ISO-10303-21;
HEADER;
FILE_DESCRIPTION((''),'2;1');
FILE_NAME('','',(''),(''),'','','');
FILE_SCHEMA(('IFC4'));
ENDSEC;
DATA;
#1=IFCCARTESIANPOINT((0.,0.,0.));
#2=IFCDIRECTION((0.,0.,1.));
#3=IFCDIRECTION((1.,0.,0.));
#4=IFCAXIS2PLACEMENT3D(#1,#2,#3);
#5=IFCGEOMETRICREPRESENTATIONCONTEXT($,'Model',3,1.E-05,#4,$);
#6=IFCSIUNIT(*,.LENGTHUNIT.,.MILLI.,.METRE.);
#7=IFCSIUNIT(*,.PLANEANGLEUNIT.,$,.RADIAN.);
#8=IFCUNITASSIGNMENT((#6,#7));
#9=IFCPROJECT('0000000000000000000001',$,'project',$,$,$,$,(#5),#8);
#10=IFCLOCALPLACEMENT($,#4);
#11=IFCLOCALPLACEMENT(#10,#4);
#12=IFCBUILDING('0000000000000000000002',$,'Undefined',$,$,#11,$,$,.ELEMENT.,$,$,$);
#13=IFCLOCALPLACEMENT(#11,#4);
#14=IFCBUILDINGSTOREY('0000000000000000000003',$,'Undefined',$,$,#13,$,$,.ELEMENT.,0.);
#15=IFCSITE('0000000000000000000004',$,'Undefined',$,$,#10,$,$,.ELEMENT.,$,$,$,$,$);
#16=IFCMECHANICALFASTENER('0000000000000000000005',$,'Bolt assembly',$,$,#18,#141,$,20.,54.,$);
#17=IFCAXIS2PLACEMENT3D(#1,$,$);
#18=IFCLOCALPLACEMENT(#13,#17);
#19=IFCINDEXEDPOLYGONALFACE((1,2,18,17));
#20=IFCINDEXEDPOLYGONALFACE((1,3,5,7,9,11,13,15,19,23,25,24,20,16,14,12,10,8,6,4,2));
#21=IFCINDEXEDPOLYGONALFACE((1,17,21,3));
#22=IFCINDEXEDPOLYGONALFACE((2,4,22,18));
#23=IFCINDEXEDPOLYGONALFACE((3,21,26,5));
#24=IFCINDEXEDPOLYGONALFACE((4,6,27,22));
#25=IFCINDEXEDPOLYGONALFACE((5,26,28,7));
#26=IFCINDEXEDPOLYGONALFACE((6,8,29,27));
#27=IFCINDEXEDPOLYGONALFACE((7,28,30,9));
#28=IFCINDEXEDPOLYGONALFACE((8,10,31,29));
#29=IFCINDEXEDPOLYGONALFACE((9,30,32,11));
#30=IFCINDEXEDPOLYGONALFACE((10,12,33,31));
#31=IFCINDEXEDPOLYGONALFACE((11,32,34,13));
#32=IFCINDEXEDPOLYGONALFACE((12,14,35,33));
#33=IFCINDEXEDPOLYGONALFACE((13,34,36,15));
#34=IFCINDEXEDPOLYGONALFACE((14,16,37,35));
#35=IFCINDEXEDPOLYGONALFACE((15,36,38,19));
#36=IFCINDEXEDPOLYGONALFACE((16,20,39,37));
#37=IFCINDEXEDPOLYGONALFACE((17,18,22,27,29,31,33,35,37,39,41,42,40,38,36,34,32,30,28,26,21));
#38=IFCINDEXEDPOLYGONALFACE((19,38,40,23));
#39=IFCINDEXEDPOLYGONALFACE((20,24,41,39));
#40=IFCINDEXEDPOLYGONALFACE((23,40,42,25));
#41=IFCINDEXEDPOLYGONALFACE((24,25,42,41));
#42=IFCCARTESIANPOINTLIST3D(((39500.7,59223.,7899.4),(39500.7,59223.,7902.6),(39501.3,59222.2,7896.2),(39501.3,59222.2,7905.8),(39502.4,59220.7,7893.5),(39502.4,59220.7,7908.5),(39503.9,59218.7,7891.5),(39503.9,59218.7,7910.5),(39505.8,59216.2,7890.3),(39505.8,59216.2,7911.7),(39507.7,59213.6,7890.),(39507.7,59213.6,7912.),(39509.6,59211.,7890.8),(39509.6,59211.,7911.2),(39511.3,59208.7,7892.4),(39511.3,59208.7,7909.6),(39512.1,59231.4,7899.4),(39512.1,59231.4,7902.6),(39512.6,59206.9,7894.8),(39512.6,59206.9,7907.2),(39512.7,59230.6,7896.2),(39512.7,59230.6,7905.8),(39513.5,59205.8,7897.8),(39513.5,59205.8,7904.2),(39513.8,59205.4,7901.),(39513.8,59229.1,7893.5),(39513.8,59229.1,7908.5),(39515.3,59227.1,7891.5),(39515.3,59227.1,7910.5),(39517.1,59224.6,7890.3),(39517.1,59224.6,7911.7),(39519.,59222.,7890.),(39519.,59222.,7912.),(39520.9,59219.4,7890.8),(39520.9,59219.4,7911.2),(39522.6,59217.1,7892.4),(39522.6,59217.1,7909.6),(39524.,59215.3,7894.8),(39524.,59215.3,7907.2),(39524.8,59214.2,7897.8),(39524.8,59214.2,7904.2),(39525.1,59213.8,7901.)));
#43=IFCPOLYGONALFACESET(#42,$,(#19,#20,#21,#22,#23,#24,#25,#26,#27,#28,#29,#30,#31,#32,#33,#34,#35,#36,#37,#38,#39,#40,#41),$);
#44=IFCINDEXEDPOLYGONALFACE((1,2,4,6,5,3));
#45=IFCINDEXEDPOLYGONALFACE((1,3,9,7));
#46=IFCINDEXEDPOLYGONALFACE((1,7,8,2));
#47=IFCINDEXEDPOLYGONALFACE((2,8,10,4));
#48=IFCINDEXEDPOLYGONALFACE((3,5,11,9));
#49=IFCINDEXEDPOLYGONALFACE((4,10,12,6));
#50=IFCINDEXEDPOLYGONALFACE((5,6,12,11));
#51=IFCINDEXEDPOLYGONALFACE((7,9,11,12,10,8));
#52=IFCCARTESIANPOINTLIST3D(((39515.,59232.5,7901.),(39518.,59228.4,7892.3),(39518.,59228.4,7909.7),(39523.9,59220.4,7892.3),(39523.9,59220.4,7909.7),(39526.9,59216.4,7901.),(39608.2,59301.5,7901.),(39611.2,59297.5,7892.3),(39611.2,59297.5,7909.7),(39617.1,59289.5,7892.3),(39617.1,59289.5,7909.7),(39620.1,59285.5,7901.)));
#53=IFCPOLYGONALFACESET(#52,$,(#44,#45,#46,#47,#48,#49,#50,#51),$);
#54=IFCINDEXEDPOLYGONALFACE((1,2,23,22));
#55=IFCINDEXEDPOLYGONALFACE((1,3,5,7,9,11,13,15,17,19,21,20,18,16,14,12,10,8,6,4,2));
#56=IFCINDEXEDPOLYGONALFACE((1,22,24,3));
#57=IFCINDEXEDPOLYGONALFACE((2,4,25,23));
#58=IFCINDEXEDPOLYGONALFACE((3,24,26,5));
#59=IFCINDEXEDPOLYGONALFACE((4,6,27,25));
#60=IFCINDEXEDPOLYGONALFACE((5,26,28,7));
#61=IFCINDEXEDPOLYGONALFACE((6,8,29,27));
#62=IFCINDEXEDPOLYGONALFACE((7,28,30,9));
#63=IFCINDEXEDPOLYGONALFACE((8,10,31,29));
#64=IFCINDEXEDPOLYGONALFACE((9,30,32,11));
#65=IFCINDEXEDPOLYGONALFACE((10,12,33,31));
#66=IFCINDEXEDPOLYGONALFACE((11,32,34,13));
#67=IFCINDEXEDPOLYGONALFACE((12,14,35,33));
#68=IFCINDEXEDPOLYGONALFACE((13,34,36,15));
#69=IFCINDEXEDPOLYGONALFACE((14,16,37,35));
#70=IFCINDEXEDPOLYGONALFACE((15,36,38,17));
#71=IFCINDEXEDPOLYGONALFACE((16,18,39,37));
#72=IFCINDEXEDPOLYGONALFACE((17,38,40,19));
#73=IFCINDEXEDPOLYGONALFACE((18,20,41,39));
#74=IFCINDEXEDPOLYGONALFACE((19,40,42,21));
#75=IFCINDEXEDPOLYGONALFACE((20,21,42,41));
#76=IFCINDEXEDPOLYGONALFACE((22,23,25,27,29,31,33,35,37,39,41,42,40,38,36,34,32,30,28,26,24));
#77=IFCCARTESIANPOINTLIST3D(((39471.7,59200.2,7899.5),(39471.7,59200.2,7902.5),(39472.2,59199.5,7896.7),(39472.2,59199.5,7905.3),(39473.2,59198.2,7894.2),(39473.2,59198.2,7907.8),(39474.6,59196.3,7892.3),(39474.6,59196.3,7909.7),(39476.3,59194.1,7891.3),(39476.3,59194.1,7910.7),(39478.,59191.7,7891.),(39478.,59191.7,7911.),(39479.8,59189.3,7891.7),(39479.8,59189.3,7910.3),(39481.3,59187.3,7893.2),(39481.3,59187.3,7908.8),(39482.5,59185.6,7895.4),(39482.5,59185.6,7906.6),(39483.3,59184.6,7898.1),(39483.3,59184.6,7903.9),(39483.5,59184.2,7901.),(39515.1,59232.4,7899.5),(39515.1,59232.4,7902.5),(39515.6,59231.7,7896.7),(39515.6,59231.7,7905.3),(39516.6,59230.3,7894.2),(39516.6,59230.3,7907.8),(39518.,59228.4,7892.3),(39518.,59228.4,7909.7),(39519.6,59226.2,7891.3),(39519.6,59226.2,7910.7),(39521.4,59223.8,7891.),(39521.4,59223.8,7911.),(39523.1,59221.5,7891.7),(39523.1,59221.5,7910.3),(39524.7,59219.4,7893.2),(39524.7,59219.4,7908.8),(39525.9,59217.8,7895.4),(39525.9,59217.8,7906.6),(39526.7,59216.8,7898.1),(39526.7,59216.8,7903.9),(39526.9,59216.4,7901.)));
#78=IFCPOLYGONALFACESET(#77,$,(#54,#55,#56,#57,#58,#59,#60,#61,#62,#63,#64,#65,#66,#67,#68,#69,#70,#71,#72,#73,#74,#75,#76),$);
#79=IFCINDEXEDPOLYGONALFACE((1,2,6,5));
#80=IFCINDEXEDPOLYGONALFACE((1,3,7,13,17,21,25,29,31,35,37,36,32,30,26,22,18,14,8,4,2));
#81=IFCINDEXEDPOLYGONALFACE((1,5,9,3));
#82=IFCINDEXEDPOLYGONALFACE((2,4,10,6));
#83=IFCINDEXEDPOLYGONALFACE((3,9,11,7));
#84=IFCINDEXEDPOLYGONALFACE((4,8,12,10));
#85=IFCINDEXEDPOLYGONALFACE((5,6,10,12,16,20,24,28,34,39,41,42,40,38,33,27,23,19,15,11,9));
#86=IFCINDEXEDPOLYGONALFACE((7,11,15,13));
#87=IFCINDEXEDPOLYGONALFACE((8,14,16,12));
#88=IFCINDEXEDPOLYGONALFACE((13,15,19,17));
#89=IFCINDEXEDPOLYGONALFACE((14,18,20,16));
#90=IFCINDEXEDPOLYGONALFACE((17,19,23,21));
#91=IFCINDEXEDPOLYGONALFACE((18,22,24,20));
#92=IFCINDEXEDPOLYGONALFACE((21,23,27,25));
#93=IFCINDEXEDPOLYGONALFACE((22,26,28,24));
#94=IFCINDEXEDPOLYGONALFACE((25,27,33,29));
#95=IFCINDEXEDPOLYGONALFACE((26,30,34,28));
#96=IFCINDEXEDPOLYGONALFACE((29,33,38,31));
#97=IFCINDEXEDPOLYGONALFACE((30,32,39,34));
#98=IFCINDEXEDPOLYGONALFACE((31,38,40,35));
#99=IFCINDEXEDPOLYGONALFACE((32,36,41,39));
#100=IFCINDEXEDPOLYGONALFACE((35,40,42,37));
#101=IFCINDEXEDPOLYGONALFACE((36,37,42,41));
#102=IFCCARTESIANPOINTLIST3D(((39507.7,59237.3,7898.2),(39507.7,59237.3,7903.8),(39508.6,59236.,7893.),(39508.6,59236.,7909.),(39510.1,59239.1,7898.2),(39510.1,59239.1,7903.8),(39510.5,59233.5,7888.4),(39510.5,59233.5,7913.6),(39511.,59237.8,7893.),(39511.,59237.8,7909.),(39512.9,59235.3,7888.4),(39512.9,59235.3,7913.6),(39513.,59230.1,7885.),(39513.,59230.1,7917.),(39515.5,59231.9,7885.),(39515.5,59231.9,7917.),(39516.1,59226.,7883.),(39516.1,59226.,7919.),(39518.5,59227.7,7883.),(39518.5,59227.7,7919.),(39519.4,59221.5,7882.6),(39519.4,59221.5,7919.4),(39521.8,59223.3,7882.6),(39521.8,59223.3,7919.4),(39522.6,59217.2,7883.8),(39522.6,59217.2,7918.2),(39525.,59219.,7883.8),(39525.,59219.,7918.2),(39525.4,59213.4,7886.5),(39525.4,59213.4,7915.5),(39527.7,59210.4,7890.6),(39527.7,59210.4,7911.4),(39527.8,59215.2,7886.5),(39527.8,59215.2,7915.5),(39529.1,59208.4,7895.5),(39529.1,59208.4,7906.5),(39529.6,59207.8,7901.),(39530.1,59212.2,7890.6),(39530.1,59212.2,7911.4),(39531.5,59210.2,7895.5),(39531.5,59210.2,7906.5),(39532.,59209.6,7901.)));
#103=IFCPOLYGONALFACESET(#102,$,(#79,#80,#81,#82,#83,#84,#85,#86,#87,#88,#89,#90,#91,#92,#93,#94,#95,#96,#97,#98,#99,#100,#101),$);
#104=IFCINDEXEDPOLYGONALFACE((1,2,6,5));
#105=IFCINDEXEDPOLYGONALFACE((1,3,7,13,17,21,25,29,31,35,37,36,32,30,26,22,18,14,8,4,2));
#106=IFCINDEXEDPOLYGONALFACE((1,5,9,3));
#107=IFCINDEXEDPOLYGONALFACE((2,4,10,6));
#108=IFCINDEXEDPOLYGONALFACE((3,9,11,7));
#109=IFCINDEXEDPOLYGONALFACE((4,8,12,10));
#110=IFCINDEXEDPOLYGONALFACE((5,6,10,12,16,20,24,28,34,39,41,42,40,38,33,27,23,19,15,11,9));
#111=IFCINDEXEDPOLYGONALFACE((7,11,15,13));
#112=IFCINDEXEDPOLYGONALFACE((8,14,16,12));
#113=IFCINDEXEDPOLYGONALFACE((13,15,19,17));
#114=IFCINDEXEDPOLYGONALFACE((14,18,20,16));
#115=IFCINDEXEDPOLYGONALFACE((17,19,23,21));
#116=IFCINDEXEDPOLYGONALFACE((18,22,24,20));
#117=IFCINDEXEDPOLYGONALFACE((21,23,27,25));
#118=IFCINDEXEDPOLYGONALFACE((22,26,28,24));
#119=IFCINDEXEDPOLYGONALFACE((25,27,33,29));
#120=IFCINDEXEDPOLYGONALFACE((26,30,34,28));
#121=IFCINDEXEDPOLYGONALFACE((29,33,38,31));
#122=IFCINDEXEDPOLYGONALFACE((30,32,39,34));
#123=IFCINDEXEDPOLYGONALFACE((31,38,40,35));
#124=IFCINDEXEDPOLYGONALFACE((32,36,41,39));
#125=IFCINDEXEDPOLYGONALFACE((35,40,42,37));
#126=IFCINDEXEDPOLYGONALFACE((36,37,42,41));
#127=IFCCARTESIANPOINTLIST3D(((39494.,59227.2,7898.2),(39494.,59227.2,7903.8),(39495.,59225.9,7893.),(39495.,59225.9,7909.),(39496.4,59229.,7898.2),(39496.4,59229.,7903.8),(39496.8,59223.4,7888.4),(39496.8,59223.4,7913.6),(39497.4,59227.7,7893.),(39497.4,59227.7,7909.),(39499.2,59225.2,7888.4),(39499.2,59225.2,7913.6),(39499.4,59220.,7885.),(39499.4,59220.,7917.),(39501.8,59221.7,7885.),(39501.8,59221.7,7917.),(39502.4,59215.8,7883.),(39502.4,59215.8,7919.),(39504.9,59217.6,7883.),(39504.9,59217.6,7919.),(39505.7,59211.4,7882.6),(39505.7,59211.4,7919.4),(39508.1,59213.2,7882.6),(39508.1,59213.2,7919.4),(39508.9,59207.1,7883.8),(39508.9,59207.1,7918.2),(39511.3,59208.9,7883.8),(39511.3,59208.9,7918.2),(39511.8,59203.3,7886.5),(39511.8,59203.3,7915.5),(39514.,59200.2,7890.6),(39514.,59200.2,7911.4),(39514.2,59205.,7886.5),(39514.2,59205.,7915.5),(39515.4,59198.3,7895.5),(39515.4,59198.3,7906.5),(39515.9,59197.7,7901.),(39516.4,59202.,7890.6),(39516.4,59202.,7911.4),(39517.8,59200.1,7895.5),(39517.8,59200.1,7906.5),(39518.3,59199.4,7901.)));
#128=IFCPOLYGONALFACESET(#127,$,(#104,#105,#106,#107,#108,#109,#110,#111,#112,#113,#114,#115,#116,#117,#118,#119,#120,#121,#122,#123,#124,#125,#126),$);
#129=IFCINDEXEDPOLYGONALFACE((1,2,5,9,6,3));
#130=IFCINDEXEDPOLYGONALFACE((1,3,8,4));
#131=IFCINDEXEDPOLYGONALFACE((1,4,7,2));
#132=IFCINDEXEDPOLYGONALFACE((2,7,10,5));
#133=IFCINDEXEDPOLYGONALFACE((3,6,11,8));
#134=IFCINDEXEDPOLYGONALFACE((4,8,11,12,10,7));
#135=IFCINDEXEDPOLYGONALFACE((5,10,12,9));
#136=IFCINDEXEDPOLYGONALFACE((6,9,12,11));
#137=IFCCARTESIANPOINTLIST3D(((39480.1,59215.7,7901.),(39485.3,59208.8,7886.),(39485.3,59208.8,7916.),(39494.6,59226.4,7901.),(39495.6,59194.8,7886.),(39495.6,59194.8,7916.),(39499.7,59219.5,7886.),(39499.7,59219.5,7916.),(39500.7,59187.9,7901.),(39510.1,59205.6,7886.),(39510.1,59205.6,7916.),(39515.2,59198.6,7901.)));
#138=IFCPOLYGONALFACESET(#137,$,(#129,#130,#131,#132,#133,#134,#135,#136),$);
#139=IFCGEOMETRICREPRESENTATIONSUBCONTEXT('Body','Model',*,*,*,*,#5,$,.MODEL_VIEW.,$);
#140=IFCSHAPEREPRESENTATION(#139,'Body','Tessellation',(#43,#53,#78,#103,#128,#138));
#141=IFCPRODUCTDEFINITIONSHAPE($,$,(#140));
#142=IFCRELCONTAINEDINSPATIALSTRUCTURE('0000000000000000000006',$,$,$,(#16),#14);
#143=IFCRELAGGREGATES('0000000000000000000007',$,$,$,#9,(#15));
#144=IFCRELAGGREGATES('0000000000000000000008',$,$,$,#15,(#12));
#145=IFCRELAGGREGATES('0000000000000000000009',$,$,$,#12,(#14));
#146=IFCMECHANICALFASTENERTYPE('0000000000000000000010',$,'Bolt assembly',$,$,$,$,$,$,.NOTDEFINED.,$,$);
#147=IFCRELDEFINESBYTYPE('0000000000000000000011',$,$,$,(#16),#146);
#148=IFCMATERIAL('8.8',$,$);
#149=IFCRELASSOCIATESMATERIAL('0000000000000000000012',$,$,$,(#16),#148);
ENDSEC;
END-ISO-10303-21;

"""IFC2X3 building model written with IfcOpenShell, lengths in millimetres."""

from ifc_helpers import new_model, si_unit, frame, origin_with_axes, origin_2d_with_axis, place, context, subcontext, project, spatial, polyline, circle, outline, extrude, source, transform, mapped, material, type_object, element, save


model = new_model("IFC2X3")

# Units and contexts
model_context = context("Model", 3, precision=1e-05, world=origin_with_axes())
body_context = subcontext(model_context, "Body", "Model", "MODEL_VIEW")
ifc_project = project(units=[si_unit("LENGTHUNIT", "METRE", prefix="MILLI"), si_unit("PLANEANGLEUNIT", "RADIAN")], contexts=[model_context])

# Site, building, storey
site_placement = place(None, origin_with_axes())
site = spatial("IfcSite", under=ifc_project, at=site_placement, Name="Undefined", CompositionType="ELEMENT")
building_placement = place(site_placement, origin_with_axes())
building = spatial("IfcBuilding", under=site, at=building_placement, Name="Undefined", CompositionType="ELEMENT")
storey_placement = place(building_placement, origin_with_axes())
storey = spatial("IfcBuildingStorey", under=building, at=storey_placement, Name="Undefined", CompositionType="ELEMENT", Elevation=0.0)

# Mechanical fastener
ifc_material_1 = material(Name="8.8")
mechanical_fastener_type = type_object("IfcMechanicalFastenerType", Name="Bolt assembly")
shared_shape_1 = source(origin_with_axes(), body_context, "Body", "SweptSolid", [
    extrude(circle(Radius=11.0, at=origin_2d_with_axis()), frame((0.0, -14.0, 0.0), z_axis=(0.0, 1.0, 0.0), x_axis=(1.0, 0.0, 0.0)), (0.0, 0.0, 1.0), 14.1),
    extrude(outline(polyline([(10.0, 0.0), (5.0, 8.7), (-5.0, 8.7), (-10.0, 0.0), (-5.0, -8.7), (5.0, -8.7), (10.0, 0.0)])), frame((0.0, -133.0, 0.0), z_axis=(0.0, 1.0, 0.0), x_axis=(1.0, 0.0, 0.0)), (0.0, 0.0, 1.0), 116.0),
    extrude(circle(Radius=10.0, at=origin_2d_with_axis()), frame((0.0, -17.0, 0.0), z_axis=(0.0, 1.0, 0.0), x_axis=(1.0, 0.0, 0.0)), (0.0, 0.0, 1.0), 54.0),
    extrude(circle(Radius=18.5, at=origin_2d_with_axis()), frame((0.0, -17.0, 0.0), z_axis=(0.0, 1.0, 0.0), x_axis=(1.0, 0.0, 0.0)), (0.0, 0.0, 1.0), 3.0),
    extrude(circle(Radius=18.5, at=origin_2d_with_axis()), frame((0.0, 0.0, 0.0), z_axis=(0.0, 1.0, 0.0), x_axis=(1.0, 0.0, 0.0)), (0.0, 0.0, 1.0), 3.0),
    extrude(outline(polyline([(17.3, 0.0), (8.7, 15.0), (-8.7, 15.0), (-17.3, 0.0), (-8.7, -15.0), (8.7, -15.0), (17.3, 0.0)])), frame((0.0, 3.0, 0.0), z_axis=(0.0, 1.0, 0.0), x_axis=(1.0, 0.0, 0.0)), (0.0, 0.0, 1.0), 18.0),
])
mechanical_fastener_1_placement = place(storey_placement, frame((39507.3, 59214.3, 7901.0), z_axis=(0.0, 0.0, -1.0), x_axis=(0.595471, -0.803377, 0.0)))
element("IfcMechanicalFastener", 1, at=mechanical_fastener_1_placement, inside=storey, type_object=mechanical_fastener_type, material=ifc_material_1, Name="Bolt assembly", NominalDiameter=20.0, NominalLength=54.0, context=body_context, shape_type="MappedRepresentation", body=[
    mapped(shared_shape_1, transform((0.0, 0.0, 0.0))),
])

save(model, "model.ifc")
